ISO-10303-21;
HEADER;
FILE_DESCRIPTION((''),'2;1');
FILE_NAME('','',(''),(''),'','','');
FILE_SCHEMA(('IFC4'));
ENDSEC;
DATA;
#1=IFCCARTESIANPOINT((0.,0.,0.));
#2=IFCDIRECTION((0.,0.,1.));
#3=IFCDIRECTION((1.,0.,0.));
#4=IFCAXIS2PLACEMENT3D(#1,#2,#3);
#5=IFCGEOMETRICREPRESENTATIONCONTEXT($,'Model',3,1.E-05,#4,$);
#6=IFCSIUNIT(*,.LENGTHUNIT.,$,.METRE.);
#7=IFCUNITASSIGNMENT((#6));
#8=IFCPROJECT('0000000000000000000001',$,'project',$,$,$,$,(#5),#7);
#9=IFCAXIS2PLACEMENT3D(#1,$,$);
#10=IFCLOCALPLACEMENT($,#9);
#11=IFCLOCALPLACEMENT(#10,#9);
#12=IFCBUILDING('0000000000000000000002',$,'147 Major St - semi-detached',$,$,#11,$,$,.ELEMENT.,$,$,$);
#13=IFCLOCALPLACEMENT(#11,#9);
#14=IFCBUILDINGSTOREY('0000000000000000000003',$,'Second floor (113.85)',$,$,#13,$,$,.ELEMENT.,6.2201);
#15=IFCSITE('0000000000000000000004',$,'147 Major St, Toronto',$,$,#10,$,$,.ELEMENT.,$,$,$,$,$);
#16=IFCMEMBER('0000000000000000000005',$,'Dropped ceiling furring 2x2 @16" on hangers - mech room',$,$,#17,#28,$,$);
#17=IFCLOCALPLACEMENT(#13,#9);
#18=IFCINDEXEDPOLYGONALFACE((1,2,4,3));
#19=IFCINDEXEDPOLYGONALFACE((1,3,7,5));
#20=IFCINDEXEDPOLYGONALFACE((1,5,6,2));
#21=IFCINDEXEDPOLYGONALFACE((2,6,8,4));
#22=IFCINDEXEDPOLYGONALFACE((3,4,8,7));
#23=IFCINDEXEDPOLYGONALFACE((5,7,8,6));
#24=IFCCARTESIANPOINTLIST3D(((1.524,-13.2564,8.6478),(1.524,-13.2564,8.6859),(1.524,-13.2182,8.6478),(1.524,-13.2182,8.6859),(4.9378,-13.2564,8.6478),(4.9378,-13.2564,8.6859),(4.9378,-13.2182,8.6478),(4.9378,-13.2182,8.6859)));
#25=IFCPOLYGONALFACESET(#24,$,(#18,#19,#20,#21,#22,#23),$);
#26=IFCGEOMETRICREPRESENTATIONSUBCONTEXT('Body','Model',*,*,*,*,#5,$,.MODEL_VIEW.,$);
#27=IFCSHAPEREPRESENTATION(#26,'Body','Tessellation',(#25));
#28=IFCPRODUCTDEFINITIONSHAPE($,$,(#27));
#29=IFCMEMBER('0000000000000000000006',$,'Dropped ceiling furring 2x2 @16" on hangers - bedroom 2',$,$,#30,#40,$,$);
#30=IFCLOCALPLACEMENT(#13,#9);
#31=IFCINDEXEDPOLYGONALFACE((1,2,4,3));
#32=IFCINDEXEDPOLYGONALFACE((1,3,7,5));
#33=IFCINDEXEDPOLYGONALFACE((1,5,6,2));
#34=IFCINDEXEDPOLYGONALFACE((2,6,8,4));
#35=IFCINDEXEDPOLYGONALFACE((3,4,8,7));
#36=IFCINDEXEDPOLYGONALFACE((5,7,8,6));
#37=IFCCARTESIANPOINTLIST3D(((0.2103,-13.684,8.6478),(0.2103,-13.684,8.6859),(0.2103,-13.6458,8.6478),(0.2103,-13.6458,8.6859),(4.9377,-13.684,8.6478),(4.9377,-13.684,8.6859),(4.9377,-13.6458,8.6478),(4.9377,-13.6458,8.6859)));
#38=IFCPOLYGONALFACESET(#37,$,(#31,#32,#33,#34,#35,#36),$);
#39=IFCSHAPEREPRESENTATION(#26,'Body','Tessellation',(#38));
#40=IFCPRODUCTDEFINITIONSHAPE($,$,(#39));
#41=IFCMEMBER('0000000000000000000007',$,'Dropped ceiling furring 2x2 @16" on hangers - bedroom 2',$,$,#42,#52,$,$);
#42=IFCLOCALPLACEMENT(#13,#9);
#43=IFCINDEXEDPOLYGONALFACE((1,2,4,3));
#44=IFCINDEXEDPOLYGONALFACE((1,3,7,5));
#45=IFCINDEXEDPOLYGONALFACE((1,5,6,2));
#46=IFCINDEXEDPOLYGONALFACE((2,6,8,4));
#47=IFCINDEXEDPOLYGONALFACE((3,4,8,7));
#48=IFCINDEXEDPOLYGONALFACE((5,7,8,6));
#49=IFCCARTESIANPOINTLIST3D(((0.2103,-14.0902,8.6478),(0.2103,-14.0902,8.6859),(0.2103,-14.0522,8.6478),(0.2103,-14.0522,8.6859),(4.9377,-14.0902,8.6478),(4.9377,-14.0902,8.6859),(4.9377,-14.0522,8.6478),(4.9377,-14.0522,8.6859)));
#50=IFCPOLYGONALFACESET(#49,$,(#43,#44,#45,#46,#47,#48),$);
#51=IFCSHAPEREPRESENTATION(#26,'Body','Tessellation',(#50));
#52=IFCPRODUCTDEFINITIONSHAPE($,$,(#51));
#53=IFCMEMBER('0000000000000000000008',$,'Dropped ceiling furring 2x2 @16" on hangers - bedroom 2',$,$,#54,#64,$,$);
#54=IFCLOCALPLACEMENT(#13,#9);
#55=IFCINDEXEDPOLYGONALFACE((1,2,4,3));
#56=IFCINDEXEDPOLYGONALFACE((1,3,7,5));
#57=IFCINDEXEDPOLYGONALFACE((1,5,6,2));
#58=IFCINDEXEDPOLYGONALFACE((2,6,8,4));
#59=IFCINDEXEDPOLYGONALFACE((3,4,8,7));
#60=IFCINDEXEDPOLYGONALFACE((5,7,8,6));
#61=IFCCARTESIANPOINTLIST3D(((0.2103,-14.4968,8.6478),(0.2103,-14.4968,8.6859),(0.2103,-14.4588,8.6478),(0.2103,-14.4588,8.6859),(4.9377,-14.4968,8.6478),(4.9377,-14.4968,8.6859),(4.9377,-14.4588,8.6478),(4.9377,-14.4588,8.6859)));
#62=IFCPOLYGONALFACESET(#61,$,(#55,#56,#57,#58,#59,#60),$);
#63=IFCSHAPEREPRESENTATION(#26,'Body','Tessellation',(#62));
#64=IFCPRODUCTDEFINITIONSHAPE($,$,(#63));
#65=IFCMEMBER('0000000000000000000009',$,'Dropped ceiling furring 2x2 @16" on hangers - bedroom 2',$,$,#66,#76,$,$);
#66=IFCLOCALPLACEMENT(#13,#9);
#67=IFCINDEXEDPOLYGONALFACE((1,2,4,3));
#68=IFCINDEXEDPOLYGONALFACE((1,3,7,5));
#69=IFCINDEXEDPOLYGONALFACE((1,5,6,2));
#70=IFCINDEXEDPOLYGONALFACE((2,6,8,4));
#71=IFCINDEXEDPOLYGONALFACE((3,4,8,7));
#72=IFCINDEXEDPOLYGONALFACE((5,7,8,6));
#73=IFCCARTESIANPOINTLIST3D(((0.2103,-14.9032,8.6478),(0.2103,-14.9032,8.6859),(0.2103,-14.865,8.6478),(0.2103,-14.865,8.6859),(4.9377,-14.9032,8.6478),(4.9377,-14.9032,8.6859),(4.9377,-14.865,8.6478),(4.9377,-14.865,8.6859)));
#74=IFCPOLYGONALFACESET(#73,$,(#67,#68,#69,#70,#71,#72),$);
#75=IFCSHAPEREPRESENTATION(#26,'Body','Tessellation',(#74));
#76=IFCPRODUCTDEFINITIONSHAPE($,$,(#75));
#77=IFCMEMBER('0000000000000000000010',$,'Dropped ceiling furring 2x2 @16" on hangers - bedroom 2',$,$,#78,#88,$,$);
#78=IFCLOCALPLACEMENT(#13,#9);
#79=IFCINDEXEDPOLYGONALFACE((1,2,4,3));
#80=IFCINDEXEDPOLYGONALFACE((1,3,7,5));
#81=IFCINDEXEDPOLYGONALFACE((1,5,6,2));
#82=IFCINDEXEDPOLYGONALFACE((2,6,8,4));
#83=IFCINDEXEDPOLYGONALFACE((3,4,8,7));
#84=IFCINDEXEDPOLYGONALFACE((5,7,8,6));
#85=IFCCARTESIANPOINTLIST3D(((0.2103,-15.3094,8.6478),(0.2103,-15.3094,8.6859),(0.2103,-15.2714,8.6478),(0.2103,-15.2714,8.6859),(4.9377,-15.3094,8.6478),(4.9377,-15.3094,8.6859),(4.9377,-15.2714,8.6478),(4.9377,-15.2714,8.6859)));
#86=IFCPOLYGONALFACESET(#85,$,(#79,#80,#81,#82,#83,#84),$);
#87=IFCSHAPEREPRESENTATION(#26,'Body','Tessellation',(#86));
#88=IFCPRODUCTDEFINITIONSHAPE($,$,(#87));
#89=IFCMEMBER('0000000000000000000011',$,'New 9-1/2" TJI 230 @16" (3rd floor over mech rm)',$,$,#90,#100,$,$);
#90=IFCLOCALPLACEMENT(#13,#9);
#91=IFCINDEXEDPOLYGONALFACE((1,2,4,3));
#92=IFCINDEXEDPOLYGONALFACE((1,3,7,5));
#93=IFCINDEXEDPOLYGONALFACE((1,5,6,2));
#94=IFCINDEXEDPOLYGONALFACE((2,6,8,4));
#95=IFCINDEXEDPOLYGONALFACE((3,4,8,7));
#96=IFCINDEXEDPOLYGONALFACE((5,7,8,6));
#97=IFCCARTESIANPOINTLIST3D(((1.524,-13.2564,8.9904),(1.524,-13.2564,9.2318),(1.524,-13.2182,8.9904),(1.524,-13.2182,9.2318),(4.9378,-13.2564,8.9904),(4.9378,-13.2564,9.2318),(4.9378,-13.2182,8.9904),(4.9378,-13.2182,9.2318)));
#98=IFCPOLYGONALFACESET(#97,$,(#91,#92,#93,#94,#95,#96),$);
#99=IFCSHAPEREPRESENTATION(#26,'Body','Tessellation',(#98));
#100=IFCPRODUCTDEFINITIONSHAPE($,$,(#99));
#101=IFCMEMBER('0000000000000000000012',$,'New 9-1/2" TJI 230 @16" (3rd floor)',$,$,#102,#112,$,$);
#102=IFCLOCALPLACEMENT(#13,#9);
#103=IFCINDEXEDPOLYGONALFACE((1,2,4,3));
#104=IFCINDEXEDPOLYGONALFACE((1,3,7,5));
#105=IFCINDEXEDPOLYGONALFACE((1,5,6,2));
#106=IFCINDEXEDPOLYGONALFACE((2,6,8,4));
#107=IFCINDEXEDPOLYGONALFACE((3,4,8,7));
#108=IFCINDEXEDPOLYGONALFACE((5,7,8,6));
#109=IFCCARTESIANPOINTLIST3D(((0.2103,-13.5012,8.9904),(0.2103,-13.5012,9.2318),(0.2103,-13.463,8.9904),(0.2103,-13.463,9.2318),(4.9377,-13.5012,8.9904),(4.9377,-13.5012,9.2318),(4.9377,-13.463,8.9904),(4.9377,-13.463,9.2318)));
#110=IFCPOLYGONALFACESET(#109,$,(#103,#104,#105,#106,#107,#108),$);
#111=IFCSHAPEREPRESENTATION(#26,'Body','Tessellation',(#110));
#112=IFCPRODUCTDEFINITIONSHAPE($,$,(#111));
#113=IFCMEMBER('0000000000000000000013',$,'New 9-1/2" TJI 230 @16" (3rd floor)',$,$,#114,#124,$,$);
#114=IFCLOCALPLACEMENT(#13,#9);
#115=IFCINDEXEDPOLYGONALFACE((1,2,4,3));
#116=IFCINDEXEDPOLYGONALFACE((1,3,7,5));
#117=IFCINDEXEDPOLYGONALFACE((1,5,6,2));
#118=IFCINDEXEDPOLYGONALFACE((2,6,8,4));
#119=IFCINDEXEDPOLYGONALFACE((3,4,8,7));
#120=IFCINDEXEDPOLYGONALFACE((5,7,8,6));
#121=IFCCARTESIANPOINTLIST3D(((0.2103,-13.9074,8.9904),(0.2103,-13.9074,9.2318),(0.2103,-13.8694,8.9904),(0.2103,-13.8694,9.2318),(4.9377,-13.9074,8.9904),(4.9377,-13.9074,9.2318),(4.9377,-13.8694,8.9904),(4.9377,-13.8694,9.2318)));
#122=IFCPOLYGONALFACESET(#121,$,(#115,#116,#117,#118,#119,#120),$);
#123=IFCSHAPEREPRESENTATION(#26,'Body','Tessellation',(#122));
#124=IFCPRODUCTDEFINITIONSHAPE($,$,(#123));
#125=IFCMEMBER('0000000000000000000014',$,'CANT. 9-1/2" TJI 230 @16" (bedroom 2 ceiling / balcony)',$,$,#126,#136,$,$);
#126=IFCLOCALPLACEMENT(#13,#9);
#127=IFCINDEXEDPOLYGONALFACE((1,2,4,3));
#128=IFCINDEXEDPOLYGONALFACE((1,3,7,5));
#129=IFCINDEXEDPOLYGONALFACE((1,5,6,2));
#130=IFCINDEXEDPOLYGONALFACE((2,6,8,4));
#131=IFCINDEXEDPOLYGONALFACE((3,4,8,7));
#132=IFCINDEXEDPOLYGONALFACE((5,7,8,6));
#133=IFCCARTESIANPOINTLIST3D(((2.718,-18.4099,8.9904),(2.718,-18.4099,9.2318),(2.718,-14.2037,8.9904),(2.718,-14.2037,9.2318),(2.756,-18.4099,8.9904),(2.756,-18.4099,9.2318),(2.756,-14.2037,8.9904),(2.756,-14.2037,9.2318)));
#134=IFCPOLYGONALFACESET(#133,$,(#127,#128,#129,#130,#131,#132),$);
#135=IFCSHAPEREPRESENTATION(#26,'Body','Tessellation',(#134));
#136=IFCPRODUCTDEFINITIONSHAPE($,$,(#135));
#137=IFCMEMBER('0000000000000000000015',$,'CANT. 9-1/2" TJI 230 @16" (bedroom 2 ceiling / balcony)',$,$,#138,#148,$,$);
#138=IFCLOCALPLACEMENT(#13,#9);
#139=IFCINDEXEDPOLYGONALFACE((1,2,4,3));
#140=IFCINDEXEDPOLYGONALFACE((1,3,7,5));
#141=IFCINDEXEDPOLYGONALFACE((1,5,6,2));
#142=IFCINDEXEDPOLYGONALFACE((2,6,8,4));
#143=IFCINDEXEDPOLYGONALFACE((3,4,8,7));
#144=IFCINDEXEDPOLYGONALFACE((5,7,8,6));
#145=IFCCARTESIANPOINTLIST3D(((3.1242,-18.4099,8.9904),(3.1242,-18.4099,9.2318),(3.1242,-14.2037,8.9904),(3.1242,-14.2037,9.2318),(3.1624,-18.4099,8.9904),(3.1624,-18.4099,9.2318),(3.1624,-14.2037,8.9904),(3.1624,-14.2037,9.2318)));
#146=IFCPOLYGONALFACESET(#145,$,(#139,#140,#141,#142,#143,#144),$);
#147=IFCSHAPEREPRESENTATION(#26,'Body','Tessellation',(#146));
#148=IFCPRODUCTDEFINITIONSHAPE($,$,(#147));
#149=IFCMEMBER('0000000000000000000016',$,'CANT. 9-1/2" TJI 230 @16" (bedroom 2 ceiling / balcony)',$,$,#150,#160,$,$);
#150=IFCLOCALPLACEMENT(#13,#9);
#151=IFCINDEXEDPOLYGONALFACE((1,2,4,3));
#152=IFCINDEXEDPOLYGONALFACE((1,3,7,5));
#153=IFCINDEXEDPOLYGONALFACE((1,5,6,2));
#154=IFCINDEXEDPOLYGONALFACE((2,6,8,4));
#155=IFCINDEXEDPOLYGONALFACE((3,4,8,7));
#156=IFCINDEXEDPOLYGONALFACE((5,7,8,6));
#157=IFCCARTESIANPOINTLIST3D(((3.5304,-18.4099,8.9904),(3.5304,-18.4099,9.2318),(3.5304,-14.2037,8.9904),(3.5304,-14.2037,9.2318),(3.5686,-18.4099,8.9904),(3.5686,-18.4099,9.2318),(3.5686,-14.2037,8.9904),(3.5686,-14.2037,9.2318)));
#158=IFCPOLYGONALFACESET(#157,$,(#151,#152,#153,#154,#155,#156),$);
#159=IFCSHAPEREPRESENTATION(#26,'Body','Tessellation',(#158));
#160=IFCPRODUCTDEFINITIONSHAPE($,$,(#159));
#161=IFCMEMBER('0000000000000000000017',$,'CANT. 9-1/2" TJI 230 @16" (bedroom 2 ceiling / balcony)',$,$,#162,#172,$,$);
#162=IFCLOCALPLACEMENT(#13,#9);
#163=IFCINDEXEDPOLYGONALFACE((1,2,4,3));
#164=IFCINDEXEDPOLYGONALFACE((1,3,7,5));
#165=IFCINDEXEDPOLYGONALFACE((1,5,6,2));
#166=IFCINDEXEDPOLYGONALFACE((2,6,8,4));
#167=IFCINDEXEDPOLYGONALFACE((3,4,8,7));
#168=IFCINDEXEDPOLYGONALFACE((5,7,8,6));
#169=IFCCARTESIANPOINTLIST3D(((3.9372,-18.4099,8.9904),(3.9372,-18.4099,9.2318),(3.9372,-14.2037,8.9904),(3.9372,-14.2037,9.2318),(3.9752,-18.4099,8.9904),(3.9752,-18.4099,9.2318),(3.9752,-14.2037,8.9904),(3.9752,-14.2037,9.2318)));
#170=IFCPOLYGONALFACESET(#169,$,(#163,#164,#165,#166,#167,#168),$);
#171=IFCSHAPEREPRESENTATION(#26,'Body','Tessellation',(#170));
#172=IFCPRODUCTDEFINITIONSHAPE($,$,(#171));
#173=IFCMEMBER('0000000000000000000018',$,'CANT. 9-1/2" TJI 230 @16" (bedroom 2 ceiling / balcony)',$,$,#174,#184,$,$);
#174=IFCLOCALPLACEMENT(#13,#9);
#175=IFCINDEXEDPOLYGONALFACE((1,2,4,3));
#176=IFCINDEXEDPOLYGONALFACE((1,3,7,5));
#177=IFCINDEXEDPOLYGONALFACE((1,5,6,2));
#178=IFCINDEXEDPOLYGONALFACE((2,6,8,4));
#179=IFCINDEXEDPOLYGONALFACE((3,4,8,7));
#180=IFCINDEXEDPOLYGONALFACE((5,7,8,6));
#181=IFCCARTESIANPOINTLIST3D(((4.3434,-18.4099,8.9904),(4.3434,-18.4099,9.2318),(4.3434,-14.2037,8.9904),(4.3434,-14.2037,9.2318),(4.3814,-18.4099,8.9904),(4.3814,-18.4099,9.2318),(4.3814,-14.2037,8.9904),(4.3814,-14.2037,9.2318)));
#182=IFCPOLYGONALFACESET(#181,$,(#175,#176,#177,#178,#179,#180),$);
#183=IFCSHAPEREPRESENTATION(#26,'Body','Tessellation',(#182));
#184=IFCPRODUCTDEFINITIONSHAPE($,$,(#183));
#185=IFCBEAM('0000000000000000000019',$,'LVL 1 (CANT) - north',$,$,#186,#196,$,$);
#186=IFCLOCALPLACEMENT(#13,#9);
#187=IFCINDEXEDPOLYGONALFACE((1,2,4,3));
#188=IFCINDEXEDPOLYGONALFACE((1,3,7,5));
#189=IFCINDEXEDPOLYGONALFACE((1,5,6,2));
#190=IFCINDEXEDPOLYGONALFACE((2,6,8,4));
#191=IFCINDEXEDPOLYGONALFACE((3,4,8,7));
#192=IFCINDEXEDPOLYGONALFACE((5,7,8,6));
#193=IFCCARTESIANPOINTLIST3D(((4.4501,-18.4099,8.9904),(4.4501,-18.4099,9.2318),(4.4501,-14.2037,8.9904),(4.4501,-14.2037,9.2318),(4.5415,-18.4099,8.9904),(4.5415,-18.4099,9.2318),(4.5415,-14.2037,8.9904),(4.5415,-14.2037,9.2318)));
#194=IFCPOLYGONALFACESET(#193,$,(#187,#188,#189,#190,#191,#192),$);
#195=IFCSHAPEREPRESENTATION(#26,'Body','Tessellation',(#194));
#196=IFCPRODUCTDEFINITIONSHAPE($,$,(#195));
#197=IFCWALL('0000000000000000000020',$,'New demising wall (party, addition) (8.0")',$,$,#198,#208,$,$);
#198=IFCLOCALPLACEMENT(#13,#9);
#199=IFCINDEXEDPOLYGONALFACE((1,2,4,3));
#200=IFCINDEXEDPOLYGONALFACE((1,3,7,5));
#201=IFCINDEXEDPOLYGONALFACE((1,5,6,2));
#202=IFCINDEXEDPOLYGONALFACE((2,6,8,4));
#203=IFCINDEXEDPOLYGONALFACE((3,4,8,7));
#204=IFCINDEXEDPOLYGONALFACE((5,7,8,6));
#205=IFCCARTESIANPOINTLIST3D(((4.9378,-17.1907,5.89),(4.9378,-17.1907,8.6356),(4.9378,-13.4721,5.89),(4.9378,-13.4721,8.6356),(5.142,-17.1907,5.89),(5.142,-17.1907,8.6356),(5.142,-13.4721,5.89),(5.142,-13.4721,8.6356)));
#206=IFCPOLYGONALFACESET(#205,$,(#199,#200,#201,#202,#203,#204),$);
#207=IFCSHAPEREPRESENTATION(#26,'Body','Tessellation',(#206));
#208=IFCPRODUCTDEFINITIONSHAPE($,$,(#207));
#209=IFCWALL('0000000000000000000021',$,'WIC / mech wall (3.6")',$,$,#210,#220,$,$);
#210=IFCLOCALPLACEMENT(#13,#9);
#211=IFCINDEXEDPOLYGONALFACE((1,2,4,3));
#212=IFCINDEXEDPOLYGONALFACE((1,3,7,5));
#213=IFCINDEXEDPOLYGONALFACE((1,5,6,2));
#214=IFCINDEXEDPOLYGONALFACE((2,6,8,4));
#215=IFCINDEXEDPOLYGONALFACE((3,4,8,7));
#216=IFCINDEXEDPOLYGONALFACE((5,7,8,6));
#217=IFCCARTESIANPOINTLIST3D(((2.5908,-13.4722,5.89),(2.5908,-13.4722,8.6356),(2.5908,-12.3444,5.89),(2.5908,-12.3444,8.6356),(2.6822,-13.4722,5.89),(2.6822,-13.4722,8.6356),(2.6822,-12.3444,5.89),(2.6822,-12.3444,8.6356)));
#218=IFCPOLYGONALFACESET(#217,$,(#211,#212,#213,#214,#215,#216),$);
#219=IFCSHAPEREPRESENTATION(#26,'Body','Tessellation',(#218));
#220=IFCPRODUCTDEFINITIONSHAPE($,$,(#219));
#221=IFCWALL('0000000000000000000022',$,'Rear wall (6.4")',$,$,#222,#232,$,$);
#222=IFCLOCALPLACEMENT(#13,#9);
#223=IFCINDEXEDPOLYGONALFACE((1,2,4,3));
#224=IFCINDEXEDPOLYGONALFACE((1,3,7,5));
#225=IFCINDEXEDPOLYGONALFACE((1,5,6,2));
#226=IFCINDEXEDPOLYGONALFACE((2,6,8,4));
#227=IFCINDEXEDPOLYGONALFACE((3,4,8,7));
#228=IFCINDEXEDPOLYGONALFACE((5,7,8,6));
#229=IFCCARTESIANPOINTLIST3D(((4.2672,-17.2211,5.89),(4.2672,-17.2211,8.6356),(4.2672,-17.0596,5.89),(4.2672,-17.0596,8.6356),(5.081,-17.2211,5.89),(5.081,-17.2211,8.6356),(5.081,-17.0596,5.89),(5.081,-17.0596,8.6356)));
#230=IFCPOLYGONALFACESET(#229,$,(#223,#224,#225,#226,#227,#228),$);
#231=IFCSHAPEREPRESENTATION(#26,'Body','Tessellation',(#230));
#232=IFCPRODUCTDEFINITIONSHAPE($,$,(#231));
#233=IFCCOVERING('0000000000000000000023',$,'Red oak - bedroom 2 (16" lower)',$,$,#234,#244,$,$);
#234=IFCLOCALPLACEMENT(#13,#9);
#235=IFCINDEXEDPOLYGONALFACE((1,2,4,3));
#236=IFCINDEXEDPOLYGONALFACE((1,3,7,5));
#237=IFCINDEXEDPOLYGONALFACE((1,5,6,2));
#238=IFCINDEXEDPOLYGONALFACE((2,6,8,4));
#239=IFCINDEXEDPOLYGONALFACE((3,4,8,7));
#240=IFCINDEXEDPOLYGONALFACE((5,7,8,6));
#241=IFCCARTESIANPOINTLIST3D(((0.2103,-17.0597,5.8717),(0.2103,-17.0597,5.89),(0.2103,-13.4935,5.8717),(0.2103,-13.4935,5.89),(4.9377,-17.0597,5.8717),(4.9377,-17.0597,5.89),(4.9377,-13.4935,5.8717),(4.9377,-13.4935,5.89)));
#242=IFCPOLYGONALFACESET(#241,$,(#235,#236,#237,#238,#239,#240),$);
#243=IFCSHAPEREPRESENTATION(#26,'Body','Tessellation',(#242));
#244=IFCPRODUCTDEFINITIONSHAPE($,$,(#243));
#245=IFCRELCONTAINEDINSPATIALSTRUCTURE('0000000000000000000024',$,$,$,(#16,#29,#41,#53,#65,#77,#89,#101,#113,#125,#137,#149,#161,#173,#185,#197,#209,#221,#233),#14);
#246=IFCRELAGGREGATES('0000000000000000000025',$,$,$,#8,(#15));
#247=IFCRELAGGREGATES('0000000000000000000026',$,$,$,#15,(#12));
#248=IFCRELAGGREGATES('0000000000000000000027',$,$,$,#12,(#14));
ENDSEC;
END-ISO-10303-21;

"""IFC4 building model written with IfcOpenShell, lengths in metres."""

from ifc_helpers import new_model, si_unit, frame, origin, origin_with_axes, place, context, subcontext, project, spatial, rectangle, extrude, element, save


model = new_model("IFC4")

# Units and contexts
model_context = context("Model", 3, precision=1e-05, world=origin_with_axes())
body_context = subcontext(model_context, "Body", "Model", "MODEL_VIEW")
ifc_project = project(units=[si_unit("LENGTHUNIT", "METRE")], contexts=[model_context])

# Site, building, storey
site_placement = place(None, origin())
site = spatial("IfcSite", under=ifc_project, at=site_placement, Name="147 Major St, Toronto", CompositionType="ELEMENT")
building_placement = place(site_placement, origin())
building = spatial("IfcBuilding", under=site, at=building_placement, Name="147 Major St - semi-detached", CompositionType="ELEMENT")
storey_placement = place(building_placement, origin())
storey = spatial("IfcBuildingStorey", under=building, at=storey_placement, Name="Second floor (113.85)", CompositionType="ELEMENT", Elevation=6.2201)

# Members
member_1_placement = place(storey_placement, frame((3.2309, -13.2373, 8.6478)))
element("IfcMember", 1, at=member_1_placement, inside=storey, Name="Dropped ceiling furring 2x2 @16\" on hangers - mech room", context=body_context, shape_type="SweptSolid", body=[
    extrude(rectangle(XDim=3.4138, YDim=0.0381), origin_with_axes(), (0.0, 0.0, 1.0), 0.0381),
])
for number, where, name in (
    (2, (2.574, -13.6649, 8.6478), "Dropped ceiling furring 2x2 @16\" on hangers - bedroom 2"),
    (3, (2.574, -14.0712, 8.6478), "Dropped ceiling furring 2x2 @16\" on hangers - bedroom 2"),
    (4, (2.574, -14.4778, 8.6478), "Dropped ceiling furring 2x2 @16\" on hangers - bedroom 2"),
    (5, (2.574, -14.8841, 8.6478), "Dropped ceiling furring 2x2 @16\" on hangers - bedroom 2"),
    (6, (2.574, -15.2904, 8.6478), "Dropped ceiling furring 2x2 @16\" on hangers - bedroom 2"),
):
    element("IfcMember", number, at=place(storey_placement, frame(where)), inside=storey, Name=name, context=body_context, shape_type="SweptSolid", body=[
        extrude(rectangle(XDim=4.7274, YDim=0.0381), origin_with_axes(), (0.0, 0.0, 1.0), 0.0381),
    ])
member_2_placement = place(storey_placement, frame((3.2309, -13.2373, 8.9904)))
element("IfcMember", 7, at=member_2_placement, inside=storey, Name="New 9-1/2\" TJI 230 @16\" (3rd floor over mech rm)", context=body_context, shape_type="SweptSolid", body=[
    extrude(rectangle(XDim=3.4138, YDim=0.0381), origin_with_axes(), (0.0, 0.0, 1.0), 0.2414),
])
for number, where, name in (
    (8, (2.574, -13.4821, 8.9904), "New 9-1/2\" TJI 230 @16\" (3rd floor)"),
    (9, (2.574, -13.8884, 8.9904), "New 9-1/2\" TJI 230 @16\" (3rd floor)"),
):
    element("IfcMember", number, at=place(storey_placement, frame(where)), inside=storey, Name=name, context=body_context, shape_type="SweptSolid", body=[
        extrude(rectangle(XDim=4.7274, YDim=0.0381), origin_with_axes(), (0.0, 0.0, 1.0), 0.2414),
    ])
for number, where, name in (
    (10, (2.737, -16.3068, 8.9904), "CANT. 9-1/2\" TJI 230 @16\" (bedroom 2 ceiling / balcony)"),
    (11, (3.1433, -16.3068, 8.9904), "CANT. 9-1/2\" TJI 230 @16\" (bedroom 2 ceiling / balcony)"),
    (12, (3.5495, -16.3068, 8.9904), "CANT. 9-1/2\" TJI 230 @16\" (bedroom 2 ceiling / balcony)"),
    (13, (3.9562, -16.3068, 8.9904), "CANT. 9-1/2\" TJI 230 @16\" (bedroom 2 ceiling / balcony)"),
    (14, (4.3624, -16.3068, 8.9904), "CANT. 9-1/2\" TJI 230 @16\" (bedroom 2 ceiling / balcony)"),
):
    element("IfcMember", number, at=place(storey_placement, frame(where)), inside=storey, Name=name, context=body_context, shape_type="SweptSolid", body=[
        extrude(rectangle(XDim=0.0381, YDim=4.2062), origin_with_axes(), (0.0, 0.0, 1.0), 0.2414),
    ])

# Beam
beam_placement = place(storey_placement, frame((4.4958, -16.3068, 8.9904)))
element("IfcBeam", 15, at=beam_placement, inside=storey, Name="LVL 1 (CANT) - north", context=body_context, shape_type="SweptSolid", body=[
    extrude(rectangle(XDim=0.0914, YDim=4.2062), origin_with_axes(), (0.0, 0.0, 1.0), 0.2414),
])

# Walls
wall_1_placement = place(storey_placement, frame((5.0399, -15.3314, 5.89)))
element("IfcWall", 16, at=wall_1_placement, inside=storey, Name="New demising wall (party, addition) (8.0\")", context=body_context, shape_type="SweptSolid", body=[
    extrude(rectangle(XDim=0.2042, YDim=3.7186), origin_with_axes(), (0.0, 0.0, 1.0), 2.7456),
])
wall_2_placement = place(storey_placement, frame((2.6365, -12.9083, 5.89)))
element("IfcWall", 17, at=wall_2_placement, inside=storey, Name="WIC / mech wall (3.6\")", context=body_context, shape_type="SweptSolid", body=[
    extrude(rectangle(XDim=0.0914, YDim=1.1278), origin_with_axes(), (0.0, 0.0, 1.0), 2.7456),
])
wall_3_placement = place(storey_placement, frame((4.6741, -17.1404, 5.89)))
element("IfcWall", 18, at=wall_3_placement, inside=storey, Name="Rear wall (6.4\")", context=body_context, shape_type="SweptSolid", body=[
    extrude(rectangle(XDim=0.8138, YDim=0.1615), origin_with_axes(), (0.0, 0.0, 1.0), 2.7456),
])

# Covering
covering_placement = place(storey_placement, frame((2.574, -15.2766, 5.8717)))
element("IfcCovering", 19, at=covering_placement, inside=storey, Name="Red oak - bedroom 2 (16\" lower)", context=body_context, shape_type="SweptSolid", body=[
    extrude(rectangle(XDim=4.7274, YDim=3.5662), origin_with_axes(), (0.0, 0.0, 1.0), 0.0183),
])

save(model, "model.ifc")
